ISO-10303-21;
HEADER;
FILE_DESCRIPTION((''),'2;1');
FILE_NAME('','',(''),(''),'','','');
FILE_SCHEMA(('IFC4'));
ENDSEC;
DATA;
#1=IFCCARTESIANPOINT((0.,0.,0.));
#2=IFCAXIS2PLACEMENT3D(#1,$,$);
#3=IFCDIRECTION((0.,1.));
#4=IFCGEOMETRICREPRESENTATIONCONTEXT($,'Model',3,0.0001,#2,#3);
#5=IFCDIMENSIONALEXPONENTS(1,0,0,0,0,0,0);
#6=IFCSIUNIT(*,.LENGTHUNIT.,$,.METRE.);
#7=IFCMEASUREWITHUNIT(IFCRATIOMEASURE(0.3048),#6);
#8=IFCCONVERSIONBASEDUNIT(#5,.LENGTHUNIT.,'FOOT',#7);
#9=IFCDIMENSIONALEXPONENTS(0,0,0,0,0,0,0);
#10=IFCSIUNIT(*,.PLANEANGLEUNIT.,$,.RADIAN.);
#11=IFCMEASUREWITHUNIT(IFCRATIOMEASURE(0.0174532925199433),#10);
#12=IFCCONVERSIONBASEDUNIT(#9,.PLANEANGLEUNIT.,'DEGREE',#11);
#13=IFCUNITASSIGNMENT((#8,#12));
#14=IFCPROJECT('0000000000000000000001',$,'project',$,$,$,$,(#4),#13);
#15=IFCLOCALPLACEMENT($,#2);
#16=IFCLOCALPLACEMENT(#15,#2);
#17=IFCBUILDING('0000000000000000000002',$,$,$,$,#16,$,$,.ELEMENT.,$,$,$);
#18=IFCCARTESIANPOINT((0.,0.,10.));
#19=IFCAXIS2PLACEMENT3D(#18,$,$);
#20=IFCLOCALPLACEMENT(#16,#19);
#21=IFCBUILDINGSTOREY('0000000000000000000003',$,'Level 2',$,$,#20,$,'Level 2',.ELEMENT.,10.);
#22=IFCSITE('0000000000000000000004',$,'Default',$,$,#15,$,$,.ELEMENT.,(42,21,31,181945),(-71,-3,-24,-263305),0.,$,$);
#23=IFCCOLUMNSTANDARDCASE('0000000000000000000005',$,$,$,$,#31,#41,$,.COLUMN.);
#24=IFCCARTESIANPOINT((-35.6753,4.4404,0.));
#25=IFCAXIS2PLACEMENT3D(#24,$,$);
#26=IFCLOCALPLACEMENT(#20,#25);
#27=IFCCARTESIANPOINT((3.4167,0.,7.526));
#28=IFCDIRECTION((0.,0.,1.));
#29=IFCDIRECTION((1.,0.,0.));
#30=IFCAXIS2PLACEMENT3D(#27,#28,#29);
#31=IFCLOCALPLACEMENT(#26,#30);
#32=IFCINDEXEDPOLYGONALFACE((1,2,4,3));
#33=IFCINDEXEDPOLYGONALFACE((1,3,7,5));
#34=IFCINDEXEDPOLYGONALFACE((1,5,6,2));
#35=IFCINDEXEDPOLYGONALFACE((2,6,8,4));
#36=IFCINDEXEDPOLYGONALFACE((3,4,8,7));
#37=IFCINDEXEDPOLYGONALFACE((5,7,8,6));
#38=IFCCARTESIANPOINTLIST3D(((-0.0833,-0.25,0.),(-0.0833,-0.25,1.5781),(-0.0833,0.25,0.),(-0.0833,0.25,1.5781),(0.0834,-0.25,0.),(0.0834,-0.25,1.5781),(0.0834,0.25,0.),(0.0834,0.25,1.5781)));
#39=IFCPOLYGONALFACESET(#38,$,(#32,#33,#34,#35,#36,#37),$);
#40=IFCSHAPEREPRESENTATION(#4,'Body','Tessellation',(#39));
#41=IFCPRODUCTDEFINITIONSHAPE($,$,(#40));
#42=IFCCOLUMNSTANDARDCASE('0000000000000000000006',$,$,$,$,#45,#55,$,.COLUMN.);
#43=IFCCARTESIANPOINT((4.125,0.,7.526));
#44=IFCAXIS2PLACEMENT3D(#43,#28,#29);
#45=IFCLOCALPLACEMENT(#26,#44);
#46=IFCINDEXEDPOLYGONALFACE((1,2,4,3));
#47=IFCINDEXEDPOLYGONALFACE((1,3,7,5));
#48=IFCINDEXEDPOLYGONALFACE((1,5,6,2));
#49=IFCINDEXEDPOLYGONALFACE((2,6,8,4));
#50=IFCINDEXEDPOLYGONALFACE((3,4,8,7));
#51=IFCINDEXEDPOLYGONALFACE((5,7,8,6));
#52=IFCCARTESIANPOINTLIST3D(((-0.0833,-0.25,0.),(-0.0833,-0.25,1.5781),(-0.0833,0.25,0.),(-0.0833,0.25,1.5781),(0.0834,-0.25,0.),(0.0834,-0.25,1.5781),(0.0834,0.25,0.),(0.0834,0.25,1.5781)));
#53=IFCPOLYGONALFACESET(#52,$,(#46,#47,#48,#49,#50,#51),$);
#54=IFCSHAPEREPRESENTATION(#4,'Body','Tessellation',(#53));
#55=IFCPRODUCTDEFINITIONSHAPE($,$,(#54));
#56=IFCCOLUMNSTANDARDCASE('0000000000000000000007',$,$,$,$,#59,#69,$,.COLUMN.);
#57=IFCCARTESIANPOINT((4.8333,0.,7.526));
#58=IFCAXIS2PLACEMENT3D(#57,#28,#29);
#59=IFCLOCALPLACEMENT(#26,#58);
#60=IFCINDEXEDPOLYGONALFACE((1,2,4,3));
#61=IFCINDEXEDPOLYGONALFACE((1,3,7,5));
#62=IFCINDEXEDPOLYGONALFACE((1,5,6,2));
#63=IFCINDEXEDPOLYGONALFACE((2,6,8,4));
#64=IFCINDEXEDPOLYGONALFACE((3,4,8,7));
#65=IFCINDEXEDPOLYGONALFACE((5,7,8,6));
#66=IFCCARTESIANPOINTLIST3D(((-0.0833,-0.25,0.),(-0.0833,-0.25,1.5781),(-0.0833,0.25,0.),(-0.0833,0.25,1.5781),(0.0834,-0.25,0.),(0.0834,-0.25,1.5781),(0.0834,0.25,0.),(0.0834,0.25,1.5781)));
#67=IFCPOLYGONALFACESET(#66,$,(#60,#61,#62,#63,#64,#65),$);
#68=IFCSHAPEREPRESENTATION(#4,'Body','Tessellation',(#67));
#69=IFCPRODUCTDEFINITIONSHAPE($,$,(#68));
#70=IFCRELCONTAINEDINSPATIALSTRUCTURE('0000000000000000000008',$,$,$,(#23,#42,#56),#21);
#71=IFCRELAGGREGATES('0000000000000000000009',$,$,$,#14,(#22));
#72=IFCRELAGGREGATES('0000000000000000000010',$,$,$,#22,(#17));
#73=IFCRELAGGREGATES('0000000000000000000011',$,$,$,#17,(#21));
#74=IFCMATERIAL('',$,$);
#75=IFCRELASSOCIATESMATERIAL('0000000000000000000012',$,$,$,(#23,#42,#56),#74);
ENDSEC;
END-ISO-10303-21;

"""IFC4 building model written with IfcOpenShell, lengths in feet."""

from ifc_helpers import new_model, entity, si_unit, converted_unit, direction, frame, origin, place, context, project, spatial, rectangle, extrude, material, element, save


model = new_model("IFC4")

# Units and contexts
model_context = context("Model", 3, precision=0.0001, world=origin(), true_north=direction((0.0, 1.0)))
ifc_project = project(units=[converted_unit("LENGTHUNIT", "FOOT", entity("IfcRatioMeasure", 0.3048), si_unit("LENGTHUNIT", "METRE"), dimensions=[1, 0, 0, 0, 0, 0, 0]), converted_unit("PLANEANGLEUNIT", "DEGREE", entity("IfcRatioMeasure", 0.0174532925199433), si_unit("PLANEANGLEUNIT", "RADIAN"), dimensions=[0, 0, 0, 0, 0, 0, 0])], contexts=[model_context])

# Site, building, storey
site_placement = place(None, origin())
site = spatial("IfcSite", under=ifc_project, at=site_placement, Name="Default", CompositionType="ELEMENT", RefLatitude=(42, 21, 31, 181945), RefLongitude=(-71, -3, -24, -263305), RefElevation=0.0)
building_placement = place(site_placement, origin())
building = spatial("IfcBuilding", under=site, at=building_placement, CompositionType="ELEMENT")
storey_placement = place(building_placement, frame((0.0, 0.0, 10.0)))
storey = spatial("IfcBuildingStorey", under=building, at=storey_placement, Name="Level 2", LongName="Level 2", CompositionType="ELEMENT", Elevation=10.0)

# Columns
ifc_material_1 = material(Name="")
placement_1 = place(storey_placement, frame((-35.6753, 4.4404, 0.0)))
for number, where, z_axis, x_axis in (
    (1, (3.4167, 0.0, 7.526), (0.0, 0.0, 1.0), (1.0, 0.0, 0.0)),
    (2, (4.125, 0.0, 7.526), (0.0, 0.0, 1.0), (1.0, 0.0, 0.0)),
    (3, (4.8333, 0.0, 7.526), (0.0, 0.0, 1.0), (1.0, 0.0, 0.0)),
):
    element("IfcColumnStandardCase", number, at=place(placement_1, frame(where, z_axis=z_axis, x_axis=x_axis)), inside=storey, material=ifc_material_1, PredefinedType="COLUMN", context=model_context, shape_type="SweptSolid", body=[
        extrude(rectangle(XDim=0.1667, YDim=0.5), origin(), (0.0, 0.0, 1.0), 1.5781),
    ])

save(model, "model.ifc")
